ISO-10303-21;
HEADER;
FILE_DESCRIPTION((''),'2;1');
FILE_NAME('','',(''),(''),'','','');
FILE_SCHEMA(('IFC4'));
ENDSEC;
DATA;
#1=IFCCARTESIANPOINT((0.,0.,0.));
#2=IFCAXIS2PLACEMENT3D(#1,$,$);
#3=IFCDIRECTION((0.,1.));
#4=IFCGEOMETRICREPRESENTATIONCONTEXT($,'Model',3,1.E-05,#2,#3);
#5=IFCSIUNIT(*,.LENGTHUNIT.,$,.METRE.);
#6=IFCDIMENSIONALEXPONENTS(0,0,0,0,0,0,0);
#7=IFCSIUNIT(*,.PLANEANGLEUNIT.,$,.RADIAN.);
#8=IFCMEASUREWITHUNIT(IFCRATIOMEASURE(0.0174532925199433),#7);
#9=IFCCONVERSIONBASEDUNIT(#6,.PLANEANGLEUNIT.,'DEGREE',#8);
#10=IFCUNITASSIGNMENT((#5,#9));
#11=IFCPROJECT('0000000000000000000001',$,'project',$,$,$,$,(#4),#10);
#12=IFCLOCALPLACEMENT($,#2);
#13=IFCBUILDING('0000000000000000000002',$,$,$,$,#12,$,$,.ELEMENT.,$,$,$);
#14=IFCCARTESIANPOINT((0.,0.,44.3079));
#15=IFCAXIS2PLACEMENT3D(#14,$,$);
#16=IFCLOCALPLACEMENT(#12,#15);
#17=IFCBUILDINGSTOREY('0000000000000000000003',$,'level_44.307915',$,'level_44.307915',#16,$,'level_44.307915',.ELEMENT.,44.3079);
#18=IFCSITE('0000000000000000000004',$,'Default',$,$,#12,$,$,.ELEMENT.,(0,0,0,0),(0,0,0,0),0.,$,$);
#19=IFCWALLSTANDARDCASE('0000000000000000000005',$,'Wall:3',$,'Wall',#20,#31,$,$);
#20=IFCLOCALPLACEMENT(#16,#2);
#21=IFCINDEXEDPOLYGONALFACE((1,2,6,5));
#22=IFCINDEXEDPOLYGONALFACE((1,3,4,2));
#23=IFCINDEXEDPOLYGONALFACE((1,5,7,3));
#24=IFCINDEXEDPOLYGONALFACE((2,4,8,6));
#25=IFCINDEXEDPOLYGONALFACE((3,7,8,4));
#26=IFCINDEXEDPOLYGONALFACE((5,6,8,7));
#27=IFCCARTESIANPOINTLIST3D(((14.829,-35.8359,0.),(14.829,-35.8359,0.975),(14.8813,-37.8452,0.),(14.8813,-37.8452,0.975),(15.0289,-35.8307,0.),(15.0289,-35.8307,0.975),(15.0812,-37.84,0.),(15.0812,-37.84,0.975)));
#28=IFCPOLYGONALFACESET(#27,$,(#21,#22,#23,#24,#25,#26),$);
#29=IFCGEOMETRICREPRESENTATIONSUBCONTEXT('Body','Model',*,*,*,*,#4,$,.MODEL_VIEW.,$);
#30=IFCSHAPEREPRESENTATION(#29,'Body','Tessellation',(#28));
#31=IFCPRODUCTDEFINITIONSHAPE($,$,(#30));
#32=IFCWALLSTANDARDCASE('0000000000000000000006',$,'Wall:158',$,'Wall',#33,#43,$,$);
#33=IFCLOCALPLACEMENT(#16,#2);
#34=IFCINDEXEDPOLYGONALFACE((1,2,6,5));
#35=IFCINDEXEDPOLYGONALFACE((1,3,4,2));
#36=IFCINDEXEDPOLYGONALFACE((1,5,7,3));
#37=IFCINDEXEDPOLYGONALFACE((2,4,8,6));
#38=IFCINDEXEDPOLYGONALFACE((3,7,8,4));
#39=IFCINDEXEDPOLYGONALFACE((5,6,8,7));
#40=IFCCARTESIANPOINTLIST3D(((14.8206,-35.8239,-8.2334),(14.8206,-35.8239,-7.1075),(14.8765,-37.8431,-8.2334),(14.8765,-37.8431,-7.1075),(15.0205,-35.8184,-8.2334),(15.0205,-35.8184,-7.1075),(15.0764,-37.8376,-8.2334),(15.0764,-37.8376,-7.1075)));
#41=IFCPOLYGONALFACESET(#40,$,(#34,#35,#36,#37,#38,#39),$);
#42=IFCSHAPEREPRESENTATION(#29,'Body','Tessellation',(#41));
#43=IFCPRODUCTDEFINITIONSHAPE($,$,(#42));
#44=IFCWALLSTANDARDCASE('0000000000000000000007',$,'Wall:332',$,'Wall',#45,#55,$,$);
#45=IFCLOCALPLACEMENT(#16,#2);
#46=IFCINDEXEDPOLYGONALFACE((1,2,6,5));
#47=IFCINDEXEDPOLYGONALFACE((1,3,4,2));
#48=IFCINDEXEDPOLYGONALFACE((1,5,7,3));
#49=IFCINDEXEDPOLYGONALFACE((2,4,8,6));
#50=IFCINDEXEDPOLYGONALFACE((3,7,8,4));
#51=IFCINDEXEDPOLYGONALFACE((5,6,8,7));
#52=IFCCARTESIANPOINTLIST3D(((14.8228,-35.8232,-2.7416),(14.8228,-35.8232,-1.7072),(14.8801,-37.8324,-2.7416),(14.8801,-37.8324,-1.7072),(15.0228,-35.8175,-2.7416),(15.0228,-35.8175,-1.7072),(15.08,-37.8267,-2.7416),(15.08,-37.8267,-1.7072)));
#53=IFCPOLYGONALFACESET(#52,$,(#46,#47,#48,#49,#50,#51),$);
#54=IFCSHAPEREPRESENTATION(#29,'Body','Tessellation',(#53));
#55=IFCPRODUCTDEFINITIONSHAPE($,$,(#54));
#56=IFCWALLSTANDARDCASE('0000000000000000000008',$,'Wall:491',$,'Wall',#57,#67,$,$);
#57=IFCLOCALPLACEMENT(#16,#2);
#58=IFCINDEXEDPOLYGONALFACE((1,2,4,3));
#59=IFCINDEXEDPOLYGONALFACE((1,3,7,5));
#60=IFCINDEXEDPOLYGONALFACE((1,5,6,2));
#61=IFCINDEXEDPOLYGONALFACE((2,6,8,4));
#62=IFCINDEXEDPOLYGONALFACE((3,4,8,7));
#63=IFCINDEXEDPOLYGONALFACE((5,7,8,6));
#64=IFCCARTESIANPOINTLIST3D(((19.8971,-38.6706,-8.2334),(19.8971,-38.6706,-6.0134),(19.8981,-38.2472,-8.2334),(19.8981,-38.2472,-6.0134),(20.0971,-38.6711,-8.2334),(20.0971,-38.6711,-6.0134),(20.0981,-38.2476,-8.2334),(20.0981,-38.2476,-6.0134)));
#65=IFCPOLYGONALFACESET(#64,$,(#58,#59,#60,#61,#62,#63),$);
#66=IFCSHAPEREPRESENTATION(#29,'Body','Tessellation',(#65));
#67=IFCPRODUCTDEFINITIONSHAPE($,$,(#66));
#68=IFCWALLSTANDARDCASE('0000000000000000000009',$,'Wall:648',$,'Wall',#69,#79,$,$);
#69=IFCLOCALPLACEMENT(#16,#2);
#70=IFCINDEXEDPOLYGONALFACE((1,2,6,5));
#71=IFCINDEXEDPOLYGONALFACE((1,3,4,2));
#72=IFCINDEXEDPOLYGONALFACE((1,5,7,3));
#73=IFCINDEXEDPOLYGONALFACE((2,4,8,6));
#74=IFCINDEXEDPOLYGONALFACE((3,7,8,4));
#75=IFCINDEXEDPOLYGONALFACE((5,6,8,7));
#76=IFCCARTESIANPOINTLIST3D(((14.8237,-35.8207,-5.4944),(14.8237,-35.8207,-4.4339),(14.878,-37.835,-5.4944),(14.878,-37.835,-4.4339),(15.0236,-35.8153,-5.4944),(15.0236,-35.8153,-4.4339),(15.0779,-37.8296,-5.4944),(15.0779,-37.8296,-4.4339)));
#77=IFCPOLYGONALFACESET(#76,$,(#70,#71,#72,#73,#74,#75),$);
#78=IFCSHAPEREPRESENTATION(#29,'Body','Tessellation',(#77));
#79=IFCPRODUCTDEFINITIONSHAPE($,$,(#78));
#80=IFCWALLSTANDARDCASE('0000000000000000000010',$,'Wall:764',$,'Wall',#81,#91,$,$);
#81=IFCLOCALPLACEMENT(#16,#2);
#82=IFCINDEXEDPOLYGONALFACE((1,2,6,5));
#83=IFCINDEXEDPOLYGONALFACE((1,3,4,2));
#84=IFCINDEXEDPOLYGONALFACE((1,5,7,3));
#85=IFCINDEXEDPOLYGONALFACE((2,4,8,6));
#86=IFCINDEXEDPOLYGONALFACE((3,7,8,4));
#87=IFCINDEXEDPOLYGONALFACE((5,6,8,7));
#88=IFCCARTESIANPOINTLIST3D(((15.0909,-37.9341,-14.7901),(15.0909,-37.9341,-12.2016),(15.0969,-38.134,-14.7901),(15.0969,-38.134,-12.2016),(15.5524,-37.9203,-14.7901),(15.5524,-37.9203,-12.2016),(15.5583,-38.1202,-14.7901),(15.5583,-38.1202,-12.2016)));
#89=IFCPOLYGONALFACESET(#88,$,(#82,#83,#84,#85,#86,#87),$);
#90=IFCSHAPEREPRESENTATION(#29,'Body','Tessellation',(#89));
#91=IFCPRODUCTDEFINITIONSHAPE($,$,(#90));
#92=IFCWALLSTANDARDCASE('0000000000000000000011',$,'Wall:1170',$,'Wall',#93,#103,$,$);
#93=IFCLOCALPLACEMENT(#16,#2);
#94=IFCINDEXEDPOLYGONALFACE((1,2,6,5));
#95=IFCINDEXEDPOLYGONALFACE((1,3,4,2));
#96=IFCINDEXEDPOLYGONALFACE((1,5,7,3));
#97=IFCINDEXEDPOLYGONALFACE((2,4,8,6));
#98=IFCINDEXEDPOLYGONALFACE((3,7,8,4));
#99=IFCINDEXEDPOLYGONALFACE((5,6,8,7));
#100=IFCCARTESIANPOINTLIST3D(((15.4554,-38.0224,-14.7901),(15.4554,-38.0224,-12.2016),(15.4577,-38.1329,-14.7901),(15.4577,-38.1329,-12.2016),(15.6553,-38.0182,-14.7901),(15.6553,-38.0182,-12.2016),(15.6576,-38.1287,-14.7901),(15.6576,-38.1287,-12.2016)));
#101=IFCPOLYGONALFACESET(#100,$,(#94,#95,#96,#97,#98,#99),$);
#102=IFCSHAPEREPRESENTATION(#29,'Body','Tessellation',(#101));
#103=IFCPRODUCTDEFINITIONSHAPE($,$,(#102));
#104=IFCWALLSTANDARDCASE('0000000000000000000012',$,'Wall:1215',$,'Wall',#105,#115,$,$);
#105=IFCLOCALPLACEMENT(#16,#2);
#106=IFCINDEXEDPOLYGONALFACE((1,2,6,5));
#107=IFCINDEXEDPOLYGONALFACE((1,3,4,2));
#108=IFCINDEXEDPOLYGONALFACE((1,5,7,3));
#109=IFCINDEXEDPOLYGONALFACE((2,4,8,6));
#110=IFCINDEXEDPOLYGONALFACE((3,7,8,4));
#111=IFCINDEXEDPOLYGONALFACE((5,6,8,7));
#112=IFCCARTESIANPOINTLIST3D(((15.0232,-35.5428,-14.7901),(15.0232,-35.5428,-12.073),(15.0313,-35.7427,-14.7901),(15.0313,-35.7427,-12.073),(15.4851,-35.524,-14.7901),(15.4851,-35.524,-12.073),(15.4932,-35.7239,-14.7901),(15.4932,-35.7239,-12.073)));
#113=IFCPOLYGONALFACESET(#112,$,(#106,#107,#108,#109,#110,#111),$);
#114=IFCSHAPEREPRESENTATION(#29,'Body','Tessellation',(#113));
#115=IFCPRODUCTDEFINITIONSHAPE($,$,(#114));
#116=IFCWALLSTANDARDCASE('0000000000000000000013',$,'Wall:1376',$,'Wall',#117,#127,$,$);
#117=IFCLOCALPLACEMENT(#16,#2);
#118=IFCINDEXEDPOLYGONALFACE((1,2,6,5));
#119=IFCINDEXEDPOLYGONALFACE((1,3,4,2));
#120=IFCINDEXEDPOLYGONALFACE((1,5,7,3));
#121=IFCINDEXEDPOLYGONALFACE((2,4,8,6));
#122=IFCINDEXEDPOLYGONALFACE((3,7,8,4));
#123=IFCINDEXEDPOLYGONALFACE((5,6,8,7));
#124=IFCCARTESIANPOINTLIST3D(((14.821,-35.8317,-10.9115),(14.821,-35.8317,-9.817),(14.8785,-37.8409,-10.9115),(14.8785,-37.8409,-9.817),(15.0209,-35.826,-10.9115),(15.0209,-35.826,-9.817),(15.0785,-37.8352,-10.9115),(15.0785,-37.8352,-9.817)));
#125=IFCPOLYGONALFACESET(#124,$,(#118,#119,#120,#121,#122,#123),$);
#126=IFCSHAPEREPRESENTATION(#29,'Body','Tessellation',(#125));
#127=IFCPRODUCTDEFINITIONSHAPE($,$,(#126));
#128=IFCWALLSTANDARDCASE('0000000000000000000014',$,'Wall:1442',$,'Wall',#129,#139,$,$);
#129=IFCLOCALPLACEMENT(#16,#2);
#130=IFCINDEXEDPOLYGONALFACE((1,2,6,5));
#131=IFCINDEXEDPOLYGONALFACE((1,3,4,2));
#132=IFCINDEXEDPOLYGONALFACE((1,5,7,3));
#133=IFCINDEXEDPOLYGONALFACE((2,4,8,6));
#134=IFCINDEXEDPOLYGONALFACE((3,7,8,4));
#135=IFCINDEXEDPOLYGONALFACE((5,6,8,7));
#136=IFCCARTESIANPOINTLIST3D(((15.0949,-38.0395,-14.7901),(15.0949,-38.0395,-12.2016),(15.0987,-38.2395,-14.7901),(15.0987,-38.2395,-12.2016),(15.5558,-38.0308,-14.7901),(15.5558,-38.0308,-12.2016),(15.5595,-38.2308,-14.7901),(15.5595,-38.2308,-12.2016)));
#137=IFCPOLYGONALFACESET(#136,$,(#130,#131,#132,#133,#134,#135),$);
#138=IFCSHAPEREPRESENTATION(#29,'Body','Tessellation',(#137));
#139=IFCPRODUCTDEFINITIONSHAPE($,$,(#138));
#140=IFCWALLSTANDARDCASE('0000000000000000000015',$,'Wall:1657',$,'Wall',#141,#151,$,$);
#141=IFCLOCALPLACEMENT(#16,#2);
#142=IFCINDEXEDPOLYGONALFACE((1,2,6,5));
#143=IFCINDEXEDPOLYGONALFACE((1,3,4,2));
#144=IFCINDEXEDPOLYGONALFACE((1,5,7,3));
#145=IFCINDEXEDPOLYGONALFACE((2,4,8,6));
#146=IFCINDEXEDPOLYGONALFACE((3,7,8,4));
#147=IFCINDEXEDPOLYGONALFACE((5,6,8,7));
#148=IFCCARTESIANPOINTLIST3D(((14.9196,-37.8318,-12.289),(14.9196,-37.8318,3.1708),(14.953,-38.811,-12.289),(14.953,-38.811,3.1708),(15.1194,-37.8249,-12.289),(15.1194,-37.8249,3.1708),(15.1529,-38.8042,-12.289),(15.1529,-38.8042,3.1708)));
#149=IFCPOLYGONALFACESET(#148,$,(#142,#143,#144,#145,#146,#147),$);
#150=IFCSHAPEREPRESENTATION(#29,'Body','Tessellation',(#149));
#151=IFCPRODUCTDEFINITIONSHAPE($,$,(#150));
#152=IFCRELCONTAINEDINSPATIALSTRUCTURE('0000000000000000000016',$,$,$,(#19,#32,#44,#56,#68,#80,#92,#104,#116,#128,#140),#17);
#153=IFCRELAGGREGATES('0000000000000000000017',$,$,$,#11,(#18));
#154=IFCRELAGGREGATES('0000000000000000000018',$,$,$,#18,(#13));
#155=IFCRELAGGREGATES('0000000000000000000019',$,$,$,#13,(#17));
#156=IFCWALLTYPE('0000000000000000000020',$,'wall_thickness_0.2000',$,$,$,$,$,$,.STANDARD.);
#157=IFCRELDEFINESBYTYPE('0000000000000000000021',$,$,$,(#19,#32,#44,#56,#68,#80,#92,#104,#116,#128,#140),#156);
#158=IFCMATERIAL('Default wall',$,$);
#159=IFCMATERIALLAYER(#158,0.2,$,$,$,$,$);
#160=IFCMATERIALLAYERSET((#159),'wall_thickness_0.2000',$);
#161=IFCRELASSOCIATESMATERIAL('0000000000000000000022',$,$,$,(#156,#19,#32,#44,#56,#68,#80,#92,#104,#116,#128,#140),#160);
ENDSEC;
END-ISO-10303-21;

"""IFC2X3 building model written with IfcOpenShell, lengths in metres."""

from ifc_helpers import new_model, entity, si_unit, converted_unit, direction, frame, origin, place, context, subcontext, project, spatial, polyline, outline, extrude, material, layer, layer_set, layer_usage, type_object, element, save


model = new_model("IFC2X3")

# Units and contexts
model_context = context("Model", 3, precision=1e-05, world=origin(), true_north=direction((0.0, 1.0)))
body_context = subcontext(model_context, "Body", "Model", "MODEL_VIEW")
ifc_project = project(units=[si_unit("LENGTHUNIT", "METRE"), converted_unit("PLANEANGLEUNIT", "DEGREE", entity("IfcRatioMeasure", 0.0174532925199433), si_unit("PLANEANGLEUNIT", "RADIAN"), dimensions=[0, 0, 0, 0, 0, 0, 0])], contexts=[model_context])

# Site, building, storey
placement_1 = place(None, origin())
site = spatial("IfcSite", under=ifc_project, at=placement_1, Name="Default", CompositionType="ELEMENT", RefLatitude=(0, 0, 0, 0), RefLongitude=(0, 0, 0, 0), RefElevation=0.0)
building = spatial("IfcBuilding", under=site, at=placement_1, CompositionType="ELEMENT")
storey_placement = place(placement_1, frame((0.0, 0.0, 44.3079)))
storey = spatial("IfcBuildingStorey", under=building, at=storey_placement, Name="level_44.307915", ObjectType="level_44.307915", LongName="level_44.307915", CompositionType="ELEMENT", Elevation=44.3079)

# Walls
ifc_material_1 = material(Name="Default wall")
ifc_layer = layer(ifc_material_1, 0.2)
ifc_layer_set = layer_set([ifc_layer], Name="wall_thickness_0.2000")
ifc_layer_usage = layer_usage(ifc_layer_set, "AXIS2", "POSITIVE", -0.1)
wall_type = type_object("IfcWallType", Name="wall_thickness_0.2000", PredefinedType="STANDARD", material=ifc_layer_set)
wall_1_placement = place(storey_placement, frame((14.9812, -37.8426, 0.0), z_axis=(0.0, 0.0, 1.0), x_axis=(-0.026032, 0.999661, 0.0)))
element("IfcWallStandardCase", 1, at=wall_1_placement, inside=storey, type_object=wall_type, material=ifc_layer_usage, Name="Wall:3", ObjectType="Wall", context=body_context, shape_type="SweptSolid", body=[
    extrude(outline(polyline([(2.01, -0.1), (2.01, 0.1), (0.0, 0.1), (0.0, -0.1), (2.01, -0.1)])), origin(), (0.0, 0.0, 1.0), 0.975),
])
placement_2 = place(placement_1, frame((0.0, 0.0, 36.0745)))
wall_2_placement = place(placement_2, frame((14.9765, -37.8404, 0.0), z_axis=(0.0, 0.0, 1.0), x_axis=(-0.027704, 0.999616, 0.0)))
element("IfcWallStandardCase", 2, at=wall_2_placement, inside=storey, type_object=wall_type, material=ifc_layer_usage, Name="Wall:158", ObjectType="Wall", context=body_context, shape_type="SweptSolid", body=[
    extrude(outline(polyline([(2.02, -0.1), (2.02, 0.1), (0.0, 0.1), (0.0, -0.1), (2.02, -0.1)])), origin(), (0.0, 0.0, 1.0), 1.1259),
])
placement_3 = place(placement_1, frame((0.0, 0.0, 41.5663)))
wall_3_placement = place(placement_3, frame((14.98, -37.8296, 0.0), z_axis=(0.0, 0.0, 1.0), x_axis=(-0.028482, 0.999594, 0.0)))
element("IfcWallStandardCase", 3, at=wall_3_placement, inside=storey, type_object=wall_type, material=ifc_layer_usage, Name="Wall:332", ObjectType="Wall", context=body_context, shape_type="SweptSolid", body=[
    extrude(outline(polyline([(2.01, -0.1), (2.01, 0.1), (0.0, 0.1), (0.0, -0.1), (2.01, -0.1)])), origin(), (0.0, 0.0, 1.0), 1.0344),
])
placement_4 = place(placement_1, frame((0.0, 0.0, 36.0745)))
wall_4_placement = place(placement_4, frame((19.9971, -38.6708, 0.0), z_axis=(0.0, 0.0, 1.0), x_axis=(0.002279, 0.999997, 0.0)))
element("IfcWallStandardCase", 4, at=wall_4_placement, inside=storey, type_object=wall_type, material=ifc_layer_usage, Name="Wall:491", ObjectType="Wall", context=body_context, shape_type="SweptSolid", body=[
    extrude(outline(polyline([(0.4234, -0.1), (0.4234, 0.1), (0.0, 0.1), (0.0, -0.1), (0.4234, -0.1)])), origin(), (0.0, 0.0, 1.0), 2.22),
])
placement_5 = place(placement_1, frame((0.0, 0.0, 38.8135)))
wall_5_placement = place(placement_5, frame((14.978, -37.8323, 0.0), z_axis=(0.0, 0.0, 1.0), x_axis=(-0.026945, 0.999637, 0.0)))
element("IfcWallStandardCase", 5, at=wall_5_placement, inside=storey, type_object=wall_type, material=ifc_layer_usage, Name="Wall:648", ObjectType="Wall", context=body_context, shape_type="SweptSolid", body=[
    extrude(outline(polyline([(2.015, -0.1), (2.015, 0.1), (0.0, 0.1), (0.0, -0.1), (2.015, -0.1)])), origin(), (0.0, 0.0, 1.0), 1.0605),
])
placement_6 = place(placement_1, frame((0.0, 0.0, 29.5178)))
wall_6_placement = place(placement_6, frame((15.5554, -38.0203, 0.0), z_axis=(0.0, 0.0, 1.0), x_axis=(-0.999554, -0.029863, 0.0)))
element("IfcWallStandardCase", 6, at=wall_6_placement, inside=storey, type_object=wall_type, material=ifc_layer_usage, Name="Wall:764", ObjectType="Wall", context=body_context, shape_type="SweptSolid", body=[
    extrude(outline(polyline([(0.4617, -0.1), (0.4617, 0.1), (0.0, 0.1), (0.0, -0.1), (0.4617, -0.1)])), origin(), (0.0, 0.0, 1.0), 2.5885),
])
placement_7 = place(placement_1, frame((0.0, 0.0, 29.5178)))
wall_7_placement = place(placement_7, frame((15.5554, -38.0203, 0.0), z_axis=(0.0, 0.0, 1.0), x_axis=(0.020791, -0.999784, 0.0)))
element("IfcWallStandardCase", 7, at=wall_7_placement, inside=storey, type_object=wall_type, material=ifc_layer_usage, Name="Wall:1170", ObjectType="Wall", context=body_context, shape_type="SweptSolid", body=[
    extrude(outline(polyline([(0.1105, -0.1), (0.1105, 0.1), (0.0, 0.1), (0.0, -0.1), (0.1105, -0.1)])), origin(), (0.0, 0.0, 1.0), 2.5885),
])
placement_8 = place(placement_1, frame((0.0, 0.0, 29.5178)))
wall_8_placement = place(placement_8, frame((15.4891, -35.6239, 0.0), z_axis=(0.0, 0.0, 1.0), x_axis=(-0.999171, -0.040715, 0.0)))
element("IfcWallStandardCase", 8, at=wall_8_placement, inside=storey, type_object=wall_type, material=ifc_layer_usage, Name="Wall:1215", ObjectType="Wall", context=body_context, shape_type="SweptSolid", body=[
    extrude(outline(polyline([(0.4623, -0.1), (0.4623, 0.1), (0.0, 0.1), (0.0, -0.1), (0.4623, -0.1)])), origin(), (0.0, 0.0, 1.0), 2.7171),
])
placement_9 = place(placement_1, frame((0.0, 0.0, 33.3964)))
wall_9_placement = place(placement_9, frame((14.9785, -37.838, 0.0), z_axis=(0.0, 0.0, 1.0), x_axis=(-0.028627, 0.99959, 0.0)))
element("IfcWallStandardCase", 9, at=wall_9_placement, inside=storey, type_object=wall_type, material=ifc_layer_usage, Name="Wall:1376", ObjectType="Wall", context=body_context, shape_type="SweptSolid", body=[
    extrude(outline(polyline([(2.01, -0.1), (2.01, 0.1), (0.0, 0.1), (0.0, -0.1), (2.01, -0.1)])), origin(), (0.0, 0.0, 1.0), 1.0945),
])
placement_10 = place(placement_1, frame((0.0, 0.0, 29.5178)))
wall_10_placement = place(placement_10, frame((15.5577, -38.1308, 0.0), z_axis=(0.0, 0.0, 1.0), x_axis=(-0.99982, -0.01897, 0.0)))
element("IfcWallStandardCase", 10, at=wall_10_placement, inside=storey, type_object=wall_type, material=ifc_layer_usage, Name="Wall:1442", ObjectType="Wall", context=body_context, shape_type="SweptSolid", body=[
    extrude(outline(polyline([(0.4609, -0.1), (0.4609, 0.1), (0.0, 0.1), (0.0, -0.1), (0.4609, -0.1)])), origin(), (0.0, 0.0, 1.0), 2.5885),
])
placement_11 = place(placement_1, frame((0.0, 0.0, 32.0189)))
wall_11_placement = place(placement_11, frame((15.0529, -38.8076, 0.0), z_axis=(0.0, 0.0, 1.0), x_axis=(-0.034109, 0.999418, 0.0)))
element("IfcWallStandardCase", 11, at=wall_11_placement, inside=storey, type_object=wall_type, material=ifc_layer_usage, Name="Wall:1657", ObjectType="Wall", context=body_context, shape_type="SweptSolid", body=[
    extrude(outline(polyline([(0.9798, -0.1), (0.9798, 0.1), (0.0, 0.1), (0.0, -0.1), (0.9798, -0.1)])), origin(), (0.0, 0.0, 1.0), 15.4598),
])

save(model, "model.ifc")
